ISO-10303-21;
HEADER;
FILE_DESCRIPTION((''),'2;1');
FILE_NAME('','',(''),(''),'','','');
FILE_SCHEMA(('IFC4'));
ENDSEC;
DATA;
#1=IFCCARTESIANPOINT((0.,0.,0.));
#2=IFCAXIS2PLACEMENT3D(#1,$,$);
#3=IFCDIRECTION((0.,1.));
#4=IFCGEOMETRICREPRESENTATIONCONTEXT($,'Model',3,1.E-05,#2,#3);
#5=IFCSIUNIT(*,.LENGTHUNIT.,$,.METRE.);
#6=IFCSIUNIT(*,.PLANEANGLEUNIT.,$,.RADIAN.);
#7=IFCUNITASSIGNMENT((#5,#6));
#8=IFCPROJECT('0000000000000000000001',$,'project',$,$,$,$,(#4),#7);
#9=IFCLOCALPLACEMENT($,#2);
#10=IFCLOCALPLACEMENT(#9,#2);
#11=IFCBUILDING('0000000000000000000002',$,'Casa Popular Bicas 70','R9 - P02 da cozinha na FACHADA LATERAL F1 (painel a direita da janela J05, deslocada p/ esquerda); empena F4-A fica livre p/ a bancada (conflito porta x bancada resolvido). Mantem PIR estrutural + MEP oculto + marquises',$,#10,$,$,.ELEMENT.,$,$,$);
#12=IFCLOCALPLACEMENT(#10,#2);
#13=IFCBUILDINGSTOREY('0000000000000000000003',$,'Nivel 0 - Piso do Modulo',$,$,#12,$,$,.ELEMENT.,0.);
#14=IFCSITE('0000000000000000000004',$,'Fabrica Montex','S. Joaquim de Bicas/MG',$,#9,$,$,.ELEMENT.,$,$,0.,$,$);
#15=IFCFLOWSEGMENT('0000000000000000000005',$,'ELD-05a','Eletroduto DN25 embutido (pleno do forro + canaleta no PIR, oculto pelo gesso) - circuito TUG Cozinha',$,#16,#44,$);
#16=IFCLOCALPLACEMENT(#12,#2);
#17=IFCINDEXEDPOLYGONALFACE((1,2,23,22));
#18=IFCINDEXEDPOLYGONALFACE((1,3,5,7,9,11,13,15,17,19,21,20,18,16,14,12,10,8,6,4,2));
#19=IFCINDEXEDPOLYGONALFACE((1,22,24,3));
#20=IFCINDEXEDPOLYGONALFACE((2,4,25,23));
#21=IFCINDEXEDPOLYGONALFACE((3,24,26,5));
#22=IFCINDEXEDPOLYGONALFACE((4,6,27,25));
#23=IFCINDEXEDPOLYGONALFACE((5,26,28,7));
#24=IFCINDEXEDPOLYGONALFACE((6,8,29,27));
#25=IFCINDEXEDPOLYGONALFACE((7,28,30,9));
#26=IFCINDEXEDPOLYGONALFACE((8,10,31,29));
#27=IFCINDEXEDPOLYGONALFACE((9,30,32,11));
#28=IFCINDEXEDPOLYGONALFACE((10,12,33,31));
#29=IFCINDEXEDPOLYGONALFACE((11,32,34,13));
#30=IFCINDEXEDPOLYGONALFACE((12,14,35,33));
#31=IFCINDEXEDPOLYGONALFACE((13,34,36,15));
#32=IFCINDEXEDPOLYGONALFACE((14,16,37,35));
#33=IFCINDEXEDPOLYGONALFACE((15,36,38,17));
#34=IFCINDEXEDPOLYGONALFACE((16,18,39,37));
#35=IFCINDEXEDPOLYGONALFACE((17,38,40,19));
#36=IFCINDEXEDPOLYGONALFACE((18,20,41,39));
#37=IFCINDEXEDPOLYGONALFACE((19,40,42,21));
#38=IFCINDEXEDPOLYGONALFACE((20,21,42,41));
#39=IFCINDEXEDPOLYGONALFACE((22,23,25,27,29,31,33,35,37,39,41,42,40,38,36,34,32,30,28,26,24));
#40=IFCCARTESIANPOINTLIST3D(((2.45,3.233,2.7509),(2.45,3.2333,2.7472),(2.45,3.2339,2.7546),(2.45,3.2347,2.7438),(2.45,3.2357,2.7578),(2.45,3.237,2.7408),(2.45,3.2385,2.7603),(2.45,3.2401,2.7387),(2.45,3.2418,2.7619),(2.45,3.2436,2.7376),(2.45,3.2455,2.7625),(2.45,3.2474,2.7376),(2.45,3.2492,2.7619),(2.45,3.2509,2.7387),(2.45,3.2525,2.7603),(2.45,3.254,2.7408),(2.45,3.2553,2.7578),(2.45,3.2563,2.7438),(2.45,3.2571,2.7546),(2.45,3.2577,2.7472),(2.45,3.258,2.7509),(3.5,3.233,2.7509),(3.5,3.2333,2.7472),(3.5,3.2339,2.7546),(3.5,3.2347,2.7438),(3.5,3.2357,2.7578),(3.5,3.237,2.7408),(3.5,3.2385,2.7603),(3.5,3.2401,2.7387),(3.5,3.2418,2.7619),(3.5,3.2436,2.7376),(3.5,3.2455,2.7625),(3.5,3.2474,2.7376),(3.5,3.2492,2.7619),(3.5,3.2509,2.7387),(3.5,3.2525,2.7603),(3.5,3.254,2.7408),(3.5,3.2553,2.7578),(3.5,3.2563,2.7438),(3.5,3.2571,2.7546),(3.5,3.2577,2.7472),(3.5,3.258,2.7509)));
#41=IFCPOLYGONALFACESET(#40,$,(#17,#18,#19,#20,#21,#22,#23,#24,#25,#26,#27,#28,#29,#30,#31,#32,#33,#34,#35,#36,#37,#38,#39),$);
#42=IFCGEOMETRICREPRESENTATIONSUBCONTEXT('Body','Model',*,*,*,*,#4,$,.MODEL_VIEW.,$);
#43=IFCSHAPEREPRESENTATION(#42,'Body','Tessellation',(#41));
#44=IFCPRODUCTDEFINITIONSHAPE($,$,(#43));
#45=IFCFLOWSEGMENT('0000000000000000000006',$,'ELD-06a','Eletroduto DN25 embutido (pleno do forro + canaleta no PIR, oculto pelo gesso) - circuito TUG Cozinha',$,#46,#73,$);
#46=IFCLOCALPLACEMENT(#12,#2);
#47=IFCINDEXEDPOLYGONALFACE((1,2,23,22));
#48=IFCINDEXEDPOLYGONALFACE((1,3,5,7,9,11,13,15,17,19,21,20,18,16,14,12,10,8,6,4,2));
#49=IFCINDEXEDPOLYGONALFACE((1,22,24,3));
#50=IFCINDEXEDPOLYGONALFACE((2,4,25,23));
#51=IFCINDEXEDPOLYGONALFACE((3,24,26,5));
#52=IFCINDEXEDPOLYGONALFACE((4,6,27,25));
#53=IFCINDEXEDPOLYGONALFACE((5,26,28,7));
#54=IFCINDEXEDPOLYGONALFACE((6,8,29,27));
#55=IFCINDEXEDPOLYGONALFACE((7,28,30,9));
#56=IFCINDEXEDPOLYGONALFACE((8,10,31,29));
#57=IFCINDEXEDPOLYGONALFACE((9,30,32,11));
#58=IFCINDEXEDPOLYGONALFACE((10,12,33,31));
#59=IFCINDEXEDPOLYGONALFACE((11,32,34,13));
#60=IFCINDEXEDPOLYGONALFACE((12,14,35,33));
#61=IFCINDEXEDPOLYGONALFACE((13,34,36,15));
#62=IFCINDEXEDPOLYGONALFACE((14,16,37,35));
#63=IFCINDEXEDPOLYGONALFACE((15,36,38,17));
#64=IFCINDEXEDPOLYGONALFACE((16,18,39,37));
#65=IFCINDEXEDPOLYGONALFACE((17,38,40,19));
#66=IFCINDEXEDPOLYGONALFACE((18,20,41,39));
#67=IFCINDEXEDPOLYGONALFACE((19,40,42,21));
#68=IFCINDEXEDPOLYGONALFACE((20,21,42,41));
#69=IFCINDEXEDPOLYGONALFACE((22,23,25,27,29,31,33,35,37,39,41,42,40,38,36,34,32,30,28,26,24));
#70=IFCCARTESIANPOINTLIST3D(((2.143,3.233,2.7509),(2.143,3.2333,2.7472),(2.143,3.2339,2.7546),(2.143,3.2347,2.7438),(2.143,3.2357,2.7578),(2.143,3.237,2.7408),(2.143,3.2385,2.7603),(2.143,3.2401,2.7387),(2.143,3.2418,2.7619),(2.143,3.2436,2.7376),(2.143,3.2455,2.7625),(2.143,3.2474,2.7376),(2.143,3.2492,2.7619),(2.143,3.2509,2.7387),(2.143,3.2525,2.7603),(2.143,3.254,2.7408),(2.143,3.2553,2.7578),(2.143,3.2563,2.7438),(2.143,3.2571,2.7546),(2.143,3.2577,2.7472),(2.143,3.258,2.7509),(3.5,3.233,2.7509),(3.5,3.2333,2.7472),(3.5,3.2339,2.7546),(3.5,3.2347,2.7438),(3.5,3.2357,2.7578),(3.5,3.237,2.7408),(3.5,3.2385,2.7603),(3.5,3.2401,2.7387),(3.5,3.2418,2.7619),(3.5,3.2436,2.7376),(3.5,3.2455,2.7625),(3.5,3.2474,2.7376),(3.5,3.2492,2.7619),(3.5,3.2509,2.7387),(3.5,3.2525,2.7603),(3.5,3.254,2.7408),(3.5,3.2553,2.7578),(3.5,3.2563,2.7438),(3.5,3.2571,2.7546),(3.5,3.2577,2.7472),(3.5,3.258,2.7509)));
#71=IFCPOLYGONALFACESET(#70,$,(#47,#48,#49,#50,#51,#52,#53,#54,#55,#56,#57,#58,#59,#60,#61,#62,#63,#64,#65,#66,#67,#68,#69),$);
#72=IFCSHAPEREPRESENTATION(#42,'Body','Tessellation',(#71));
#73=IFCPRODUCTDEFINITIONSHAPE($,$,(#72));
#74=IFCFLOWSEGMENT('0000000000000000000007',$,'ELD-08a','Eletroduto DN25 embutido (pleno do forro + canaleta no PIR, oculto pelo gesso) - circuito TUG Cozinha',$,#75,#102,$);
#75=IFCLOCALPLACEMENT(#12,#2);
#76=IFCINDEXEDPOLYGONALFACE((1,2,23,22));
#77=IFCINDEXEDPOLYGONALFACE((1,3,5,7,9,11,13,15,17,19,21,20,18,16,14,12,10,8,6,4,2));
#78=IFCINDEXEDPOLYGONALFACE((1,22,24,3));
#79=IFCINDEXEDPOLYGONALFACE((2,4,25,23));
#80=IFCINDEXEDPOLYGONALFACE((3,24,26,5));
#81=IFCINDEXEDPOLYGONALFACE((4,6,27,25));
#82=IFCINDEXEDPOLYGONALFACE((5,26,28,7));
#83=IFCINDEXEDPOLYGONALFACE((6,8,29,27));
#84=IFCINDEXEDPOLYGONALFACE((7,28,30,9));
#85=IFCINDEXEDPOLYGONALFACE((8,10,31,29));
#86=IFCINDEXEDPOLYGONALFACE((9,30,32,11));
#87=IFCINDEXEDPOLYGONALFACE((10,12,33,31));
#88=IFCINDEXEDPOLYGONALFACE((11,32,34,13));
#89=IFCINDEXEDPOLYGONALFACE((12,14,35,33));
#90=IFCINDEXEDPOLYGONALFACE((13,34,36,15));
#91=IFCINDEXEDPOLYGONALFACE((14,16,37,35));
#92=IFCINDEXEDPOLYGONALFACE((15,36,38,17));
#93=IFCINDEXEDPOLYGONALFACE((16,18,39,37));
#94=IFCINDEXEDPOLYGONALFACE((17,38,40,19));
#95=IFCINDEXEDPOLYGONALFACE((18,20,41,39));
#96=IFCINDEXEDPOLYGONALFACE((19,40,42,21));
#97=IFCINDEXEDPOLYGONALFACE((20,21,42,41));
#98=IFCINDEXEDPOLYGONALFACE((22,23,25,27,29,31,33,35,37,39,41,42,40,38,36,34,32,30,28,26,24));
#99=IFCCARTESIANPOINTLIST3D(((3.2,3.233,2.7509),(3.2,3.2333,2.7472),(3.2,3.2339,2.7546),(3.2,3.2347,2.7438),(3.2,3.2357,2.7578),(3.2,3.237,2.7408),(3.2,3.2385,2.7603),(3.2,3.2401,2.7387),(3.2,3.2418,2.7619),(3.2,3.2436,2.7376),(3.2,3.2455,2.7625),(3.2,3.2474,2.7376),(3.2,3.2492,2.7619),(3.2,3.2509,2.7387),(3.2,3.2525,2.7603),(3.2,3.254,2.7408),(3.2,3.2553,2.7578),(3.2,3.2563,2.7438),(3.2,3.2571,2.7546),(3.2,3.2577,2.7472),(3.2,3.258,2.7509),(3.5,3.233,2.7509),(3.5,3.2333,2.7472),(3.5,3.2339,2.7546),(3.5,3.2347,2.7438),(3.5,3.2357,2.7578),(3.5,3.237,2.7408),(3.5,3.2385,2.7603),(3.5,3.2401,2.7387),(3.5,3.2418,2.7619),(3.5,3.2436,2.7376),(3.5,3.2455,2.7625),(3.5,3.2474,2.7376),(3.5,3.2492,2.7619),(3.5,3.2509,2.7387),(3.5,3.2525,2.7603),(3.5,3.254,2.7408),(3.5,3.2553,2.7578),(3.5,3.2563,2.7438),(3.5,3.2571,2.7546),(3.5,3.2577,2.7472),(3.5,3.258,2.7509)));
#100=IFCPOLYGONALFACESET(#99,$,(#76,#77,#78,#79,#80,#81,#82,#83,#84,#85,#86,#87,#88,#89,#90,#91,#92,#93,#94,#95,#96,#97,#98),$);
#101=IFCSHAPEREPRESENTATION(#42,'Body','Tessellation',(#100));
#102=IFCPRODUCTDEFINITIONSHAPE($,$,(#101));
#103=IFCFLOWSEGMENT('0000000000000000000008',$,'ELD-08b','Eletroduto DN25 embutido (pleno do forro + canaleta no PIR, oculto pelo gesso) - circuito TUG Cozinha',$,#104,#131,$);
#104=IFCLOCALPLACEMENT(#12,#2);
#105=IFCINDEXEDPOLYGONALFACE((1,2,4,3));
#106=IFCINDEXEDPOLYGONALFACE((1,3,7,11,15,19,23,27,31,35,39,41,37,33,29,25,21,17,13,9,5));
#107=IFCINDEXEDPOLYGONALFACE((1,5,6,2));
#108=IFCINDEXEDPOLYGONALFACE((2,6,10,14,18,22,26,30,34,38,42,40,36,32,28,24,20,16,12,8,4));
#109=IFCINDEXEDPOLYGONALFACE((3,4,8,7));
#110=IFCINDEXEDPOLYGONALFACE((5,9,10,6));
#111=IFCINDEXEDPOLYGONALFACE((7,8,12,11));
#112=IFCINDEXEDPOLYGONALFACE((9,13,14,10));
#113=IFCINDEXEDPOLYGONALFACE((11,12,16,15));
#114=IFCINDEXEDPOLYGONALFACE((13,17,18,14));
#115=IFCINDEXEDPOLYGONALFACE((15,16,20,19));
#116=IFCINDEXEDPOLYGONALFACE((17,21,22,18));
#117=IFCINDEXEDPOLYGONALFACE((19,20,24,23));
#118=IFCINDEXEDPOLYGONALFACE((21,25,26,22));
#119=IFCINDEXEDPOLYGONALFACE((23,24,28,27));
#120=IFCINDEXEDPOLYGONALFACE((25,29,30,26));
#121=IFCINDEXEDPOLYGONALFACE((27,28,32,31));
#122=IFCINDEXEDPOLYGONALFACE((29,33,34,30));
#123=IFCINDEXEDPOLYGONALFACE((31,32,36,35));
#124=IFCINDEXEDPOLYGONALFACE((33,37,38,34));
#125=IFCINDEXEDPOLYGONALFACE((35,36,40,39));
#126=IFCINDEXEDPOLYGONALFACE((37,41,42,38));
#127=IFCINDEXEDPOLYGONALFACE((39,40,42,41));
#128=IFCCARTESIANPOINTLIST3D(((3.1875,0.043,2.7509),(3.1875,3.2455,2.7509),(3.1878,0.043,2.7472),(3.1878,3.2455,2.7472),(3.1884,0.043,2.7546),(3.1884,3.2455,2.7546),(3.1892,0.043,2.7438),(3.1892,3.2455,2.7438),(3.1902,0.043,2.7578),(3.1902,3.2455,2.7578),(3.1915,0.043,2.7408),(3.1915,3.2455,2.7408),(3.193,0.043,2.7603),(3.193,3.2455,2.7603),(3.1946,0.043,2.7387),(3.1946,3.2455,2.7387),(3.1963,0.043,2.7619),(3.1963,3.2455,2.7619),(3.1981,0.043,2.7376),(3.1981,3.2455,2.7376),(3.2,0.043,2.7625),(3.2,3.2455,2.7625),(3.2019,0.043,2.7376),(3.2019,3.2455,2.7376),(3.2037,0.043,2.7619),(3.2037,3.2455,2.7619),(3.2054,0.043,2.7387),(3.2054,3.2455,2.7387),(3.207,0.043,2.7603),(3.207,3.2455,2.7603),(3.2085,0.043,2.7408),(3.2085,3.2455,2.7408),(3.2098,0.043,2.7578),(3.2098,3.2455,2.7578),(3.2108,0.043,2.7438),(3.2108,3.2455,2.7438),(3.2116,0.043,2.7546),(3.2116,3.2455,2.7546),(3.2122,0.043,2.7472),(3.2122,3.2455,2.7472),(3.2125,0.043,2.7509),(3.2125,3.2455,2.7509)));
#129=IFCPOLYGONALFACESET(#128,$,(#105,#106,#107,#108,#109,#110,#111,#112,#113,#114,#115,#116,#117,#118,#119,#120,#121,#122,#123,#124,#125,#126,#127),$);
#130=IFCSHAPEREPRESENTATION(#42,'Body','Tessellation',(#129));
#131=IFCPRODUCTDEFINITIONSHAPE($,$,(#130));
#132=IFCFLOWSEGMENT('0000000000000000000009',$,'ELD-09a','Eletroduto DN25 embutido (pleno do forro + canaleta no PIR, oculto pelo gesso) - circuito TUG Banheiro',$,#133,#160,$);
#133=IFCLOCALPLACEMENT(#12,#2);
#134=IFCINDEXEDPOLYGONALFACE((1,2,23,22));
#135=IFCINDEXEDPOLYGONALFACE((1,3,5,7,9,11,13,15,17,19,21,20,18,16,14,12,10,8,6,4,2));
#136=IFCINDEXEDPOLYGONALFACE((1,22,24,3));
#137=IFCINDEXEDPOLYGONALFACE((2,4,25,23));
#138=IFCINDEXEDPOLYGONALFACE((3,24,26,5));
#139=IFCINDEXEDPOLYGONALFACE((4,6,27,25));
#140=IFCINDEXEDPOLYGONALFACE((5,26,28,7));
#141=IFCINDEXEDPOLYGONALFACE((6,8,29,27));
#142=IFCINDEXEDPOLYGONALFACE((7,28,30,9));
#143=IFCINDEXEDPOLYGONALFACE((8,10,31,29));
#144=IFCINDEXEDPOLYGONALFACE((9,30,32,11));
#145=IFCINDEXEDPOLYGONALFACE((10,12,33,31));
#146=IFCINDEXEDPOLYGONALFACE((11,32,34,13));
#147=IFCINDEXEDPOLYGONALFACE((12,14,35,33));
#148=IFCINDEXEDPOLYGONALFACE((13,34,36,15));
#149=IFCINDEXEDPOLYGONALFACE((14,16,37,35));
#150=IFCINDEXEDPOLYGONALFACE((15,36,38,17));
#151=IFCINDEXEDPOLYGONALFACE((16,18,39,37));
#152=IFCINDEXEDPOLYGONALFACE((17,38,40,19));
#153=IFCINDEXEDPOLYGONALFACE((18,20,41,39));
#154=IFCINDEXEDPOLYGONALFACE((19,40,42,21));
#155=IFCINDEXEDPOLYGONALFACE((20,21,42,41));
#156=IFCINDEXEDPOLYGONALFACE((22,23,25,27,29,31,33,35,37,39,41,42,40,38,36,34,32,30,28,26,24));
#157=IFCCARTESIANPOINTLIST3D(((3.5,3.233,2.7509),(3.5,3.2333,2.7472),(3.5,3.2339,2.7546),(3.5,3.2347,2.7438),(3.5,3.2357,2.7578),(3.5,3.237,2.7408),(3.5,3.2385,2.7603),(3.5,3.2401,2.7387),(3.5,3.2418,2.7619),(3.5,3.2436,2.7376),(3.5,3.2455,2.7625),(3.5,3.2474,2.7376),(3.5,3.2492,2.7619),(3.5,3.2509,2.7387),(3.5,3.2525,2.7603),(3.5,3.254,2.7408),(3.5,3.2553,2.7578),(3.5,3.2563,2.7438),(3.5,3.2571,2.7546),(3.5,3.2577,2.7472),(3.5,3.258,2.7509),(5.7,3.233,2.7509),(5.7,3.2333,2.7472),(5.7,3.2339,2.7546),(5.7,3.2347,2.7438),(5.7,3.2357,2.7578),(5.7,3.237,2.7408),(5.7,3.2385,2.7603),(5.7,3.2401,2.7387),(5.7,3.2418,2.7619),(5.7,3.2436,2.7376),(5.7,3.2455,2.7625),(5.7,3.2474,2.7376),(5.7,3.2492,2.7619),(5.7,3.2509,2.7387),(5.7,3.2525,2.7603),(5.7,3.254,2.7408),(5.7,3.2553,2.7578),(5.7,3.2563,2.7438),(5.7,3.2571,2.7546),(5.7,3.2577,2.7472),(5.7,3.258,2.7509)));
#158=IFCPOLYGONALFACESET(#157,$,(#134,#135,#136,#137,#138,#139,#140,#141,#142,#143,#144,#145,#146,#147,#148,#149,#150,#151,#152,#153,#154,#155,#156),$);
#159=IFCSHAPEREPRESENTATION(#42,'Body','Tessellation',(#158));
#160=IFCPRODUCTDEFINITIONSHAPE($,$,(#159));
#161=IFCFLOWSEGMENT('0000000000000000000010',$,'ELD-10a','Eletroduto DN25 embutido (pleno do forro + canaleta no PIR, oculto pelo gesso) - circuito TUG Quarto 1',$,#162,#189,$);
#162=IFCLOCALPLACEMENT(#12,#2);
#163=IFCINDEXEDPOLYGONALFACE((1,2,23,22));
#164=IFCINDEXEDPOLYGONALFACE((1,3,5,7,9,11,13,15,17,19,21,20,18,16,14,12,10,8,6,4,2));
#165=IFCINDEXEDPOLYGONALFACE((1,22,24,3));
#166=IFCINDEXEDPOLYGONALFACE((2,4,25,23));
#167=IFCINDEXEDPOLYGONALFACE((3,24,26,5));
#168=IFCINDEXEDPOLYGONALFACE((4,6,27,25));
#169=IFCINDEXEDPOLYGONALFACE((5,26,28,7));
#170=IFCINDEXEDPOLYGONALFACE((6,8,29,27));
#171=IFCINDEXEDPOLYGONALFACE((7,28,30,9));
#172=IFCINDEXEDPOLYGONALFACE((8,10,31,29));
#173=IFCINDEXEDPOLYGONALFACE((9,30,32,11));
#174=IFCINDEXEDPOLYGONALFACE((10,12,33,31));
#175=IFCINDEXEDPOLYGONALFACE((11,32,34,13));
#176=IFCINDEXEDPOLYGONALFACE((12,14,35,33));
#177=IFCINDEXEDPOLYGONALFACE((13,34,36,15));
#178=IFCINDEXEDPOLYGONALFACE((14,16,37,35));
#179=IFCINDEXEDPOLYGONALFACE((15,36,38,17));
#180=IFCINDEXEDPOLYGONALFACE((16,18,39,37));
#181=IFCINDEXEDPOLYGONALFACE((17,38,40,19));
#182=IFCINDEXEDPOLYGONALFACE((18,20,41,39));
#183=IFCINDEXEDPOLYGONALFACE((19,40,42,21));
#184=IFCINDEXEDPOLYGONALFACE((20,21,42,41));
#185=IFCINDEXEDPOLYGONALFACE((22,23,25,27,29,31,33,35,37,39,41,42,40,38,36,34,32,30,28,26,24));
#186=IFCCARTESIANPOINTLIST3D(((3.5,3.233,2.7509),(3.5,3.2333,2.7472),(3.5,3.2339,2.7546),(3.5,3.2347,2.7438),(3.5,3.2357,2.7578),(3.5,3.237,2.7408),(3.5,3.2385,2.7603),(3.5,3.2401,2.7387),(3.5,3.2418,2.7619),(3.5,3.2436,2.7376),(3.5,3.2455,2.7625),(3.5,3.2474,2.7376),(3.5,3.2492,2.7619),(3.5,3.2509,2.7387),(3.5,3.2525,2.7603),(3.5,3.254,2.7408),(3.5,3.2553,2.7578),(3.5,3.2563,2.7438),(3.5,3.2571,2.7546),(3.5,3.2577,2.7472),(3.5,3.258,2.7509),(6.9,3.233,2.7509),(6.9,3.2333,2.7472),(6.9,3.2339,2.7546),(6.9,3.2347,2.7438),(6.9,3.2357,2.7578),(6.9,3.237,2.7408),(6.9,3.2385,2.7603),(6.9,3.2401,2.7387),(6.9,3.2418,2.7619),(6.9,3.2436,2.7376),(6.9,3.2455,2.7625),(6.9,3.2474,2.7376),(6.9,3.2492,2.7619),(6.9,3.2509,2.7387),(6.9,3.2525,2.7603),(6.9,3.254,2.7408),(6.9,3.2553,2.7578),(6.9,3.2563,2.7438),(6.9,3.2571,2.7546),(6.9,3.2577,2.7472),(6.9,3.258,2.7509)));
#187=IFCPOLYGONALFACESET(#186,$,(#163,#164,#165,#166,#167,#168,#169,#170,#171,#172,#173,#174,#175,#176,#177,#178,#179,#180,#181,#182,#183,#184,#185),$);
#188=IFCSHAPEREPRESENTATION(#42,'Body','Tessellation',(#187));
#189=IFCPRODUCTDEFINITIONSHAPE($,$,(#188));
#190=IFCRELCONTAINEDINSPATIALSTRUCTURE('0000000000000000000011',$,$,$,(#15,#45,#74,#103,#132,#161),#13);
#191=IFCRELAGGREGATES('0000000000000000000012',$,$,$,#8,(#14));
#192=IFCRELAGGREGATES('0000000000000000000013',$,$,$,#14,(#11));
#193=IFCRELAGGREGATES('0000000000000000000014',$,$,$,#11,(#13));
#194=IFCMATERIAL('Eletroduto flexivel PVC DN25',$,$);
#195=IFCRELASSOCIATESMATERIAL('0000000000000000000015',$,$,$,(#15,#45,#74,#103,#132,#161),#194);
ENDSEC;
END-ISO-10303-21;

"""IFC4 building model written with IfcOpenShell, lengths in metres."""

from ifc_helpers import new_model, si_unit, direction, frame, origin, origin_2d, place, context, subcontext, project, spatial, circle, extrude, material, element, save


model = new_model("IFC4")

# Units and contexts
model_context = context("Model", 3, precision=1e-05, world=origin(), true_north=direction((0.0, 1.0)))
body_context = subcontext(model_context, "Body", "Model", "MODEL_VIEW")
ifc_project = project(units=[si_unit("LENGTHUNIT", "METRE"), si_unit("PLANEANGLEUNIT", "RADIAN")], contexts=[model_context])

# Site, building, storey
site_placement = place(None, origin())
site = spatial("IfcSite", under=ifc_project, at=site_placement, Name="Fabrica Montex", Description="S. Joaquim de Bicas/MG", CompositionType="ELEMENT", RefElevation=0.0)
building_placement = place(site_placement, origin())
building = spatial("IfcBuilding", under=site, at=building_placement, Name="Casa Popular Bicas 70", Description="R9 - P02 da cozinha na FACHADA LATERAL F1 (painel a direita da janela J05, deslocada p/ esquerda); empena F4-A fica livre p/ a bancada (conflito porta x bancada resolvido). Mantem PIR estrutural + MEP oculto + marquises", CompositionType="ELEMENT")
storey_placement = place(building_placement, origin())
storey = spatial("IfcBuildingStorey", under=building, at=storey_placement, Name="Nivel 0 - Piso do Modulo", CompositionType="ELEMENT", Elevation=0.0)

# Flow segments
ifc_material_1 = material(Name="Eletroduto flexivel PVC DN25")
flow_segment_1_placement = place(storey_placement, frame((3.5, 3.2455, 2.75), z_axis=(-1.0, 0.0, 0.0), x_axis=(0.0, 0.0, 1.0)))
element("IfcFlowSegment", 1, at=flow_segment_1_placement, inside=storey, material=ifc_material_1, Name="ELD-05a", Description="Eletroduto DN25 embutido (pleno do forro + canaleta no PIR, oculto pelo gesso) - circuito TUG Cozinha", context=body_context, shape_type="SweptSolid", body=[
    extrude(circle(Radius=0.0125, at=origin_2d()), origin(), (0.0, 0.0, 1.0), 1.05),
])
for number, where, z_axis, x_axis, name in (
    (2, (3.5, 3.2455, 2.75), (-1.0, 0.0, 0.0), (0.0, 0.0, 1.0), "ELD-06a"),
):
    element("IfcFlowSegment", number, at=place(storey_placement, frame(where, z_axis=z_axis, x_axis=x_axis)), inside=storey, material=ifc_material_1, Name=name, Description="Eletroduto DN25 embutido (pleno do forro + canaleta no PIR, oculto pelo gesso) - circuito TUG Cozinha", context=body_context, shape_type="SweptSolid", body=[
        extrude(circle(Radius=0.0125, at=origin_2d()), origin(), (0.0, 0.0, 1.0), 1.357),
    ])
flow_segment_2_placement = place(storey_placement, frame((3.5, 3.2455, 2.75), z_axis=(-1.0, 0.0, 0.0), x_axis=(0.0, 0.0, 1.0)))
element("IfcFlowSegment", 3, at=flow_segment_2_placement, inside=storey, material=ifc_material_1, Name="ELD-08a", Description="Eletroduto DN25 embutido (pleno do forro + canaleta no PIR, oculto pelo gesso) - circuito TUG Cozinha", context=body_context, shape_type="SweptSolid", body=[
    extrude(circle(Radius=0.0125, at=origin_2d()), origin(), (0.0, 0.0, 1.0), 0.3),
])
flow_segment_3_placement = place(storey_placement, frame((3.2, 3.2455, 2.75), z_axis=(0.0, -1.0, 0.0), x_axis=(0.0, 0.0, 1.0)))
element("IfcFlowSegment", 4, at=flow_segment_3_placement, inside=storey, material=ifc_material_1, Name="ELD-08b", Description="Eletroduto DN25 embutido (pleno do forro + canaleta no PIR, oculto pelo gesso) - circuito TUG Cozinha", context=body_context, shape_type="SweptSolid", body=[
    extrude(circle(Radius=0.0125, at=origin_2d()), origin(), (0.0, 0.0, 1.0), 3.2025),
])
flow_segment_4_placement = place(storey_placement, frame((3.5, 3.2455, 2.75), z_axis=(1.0, 0.0, 0.0), x_axis=(0.0, 0.0, 1.0)))
element("IfcFlowSegment", 5, at=flow_segment_4_placement, inside=storey, material=ifc_material_1, Name="ELD-09a", Description="Eletroduto DN25 embutido (pleno do forro + canaleta no PIR, oculto pelo gesso) - circuito TUG Banheiro", context=body_context, shape_type="SweptSolid", body=[
    extrude(circle(Radius=0.0125, at=origin_2d()), origin(), (0.0, 0.0, 1.0), 2.2),
])
flow_segment_5_placement = place(storey_placement, frame((3.5, 3.2455, 2.75), z_axis=(1.0, 0.0, 0.0), x_axis=(0.0, 0.0, 1.0)))
element("IfcFlowSegment", 6, at=flow_segment_5_placement, inside=storey, material=ifc_material_1, Name="ELD-10a", Description="Eletroduto DN25 embutido (pleno do forro + canaleta no PIR, oculto pelo gesso) - circuito TUG Quarto 1", context=body_context, shape_type="SweptSolid", body=[
    extrude(circle(Radius=0.0125, at=origin_2d()), origin(), (0.0, 0.0, 1.0), 3.4),
])

save(model, "model.ifc")
